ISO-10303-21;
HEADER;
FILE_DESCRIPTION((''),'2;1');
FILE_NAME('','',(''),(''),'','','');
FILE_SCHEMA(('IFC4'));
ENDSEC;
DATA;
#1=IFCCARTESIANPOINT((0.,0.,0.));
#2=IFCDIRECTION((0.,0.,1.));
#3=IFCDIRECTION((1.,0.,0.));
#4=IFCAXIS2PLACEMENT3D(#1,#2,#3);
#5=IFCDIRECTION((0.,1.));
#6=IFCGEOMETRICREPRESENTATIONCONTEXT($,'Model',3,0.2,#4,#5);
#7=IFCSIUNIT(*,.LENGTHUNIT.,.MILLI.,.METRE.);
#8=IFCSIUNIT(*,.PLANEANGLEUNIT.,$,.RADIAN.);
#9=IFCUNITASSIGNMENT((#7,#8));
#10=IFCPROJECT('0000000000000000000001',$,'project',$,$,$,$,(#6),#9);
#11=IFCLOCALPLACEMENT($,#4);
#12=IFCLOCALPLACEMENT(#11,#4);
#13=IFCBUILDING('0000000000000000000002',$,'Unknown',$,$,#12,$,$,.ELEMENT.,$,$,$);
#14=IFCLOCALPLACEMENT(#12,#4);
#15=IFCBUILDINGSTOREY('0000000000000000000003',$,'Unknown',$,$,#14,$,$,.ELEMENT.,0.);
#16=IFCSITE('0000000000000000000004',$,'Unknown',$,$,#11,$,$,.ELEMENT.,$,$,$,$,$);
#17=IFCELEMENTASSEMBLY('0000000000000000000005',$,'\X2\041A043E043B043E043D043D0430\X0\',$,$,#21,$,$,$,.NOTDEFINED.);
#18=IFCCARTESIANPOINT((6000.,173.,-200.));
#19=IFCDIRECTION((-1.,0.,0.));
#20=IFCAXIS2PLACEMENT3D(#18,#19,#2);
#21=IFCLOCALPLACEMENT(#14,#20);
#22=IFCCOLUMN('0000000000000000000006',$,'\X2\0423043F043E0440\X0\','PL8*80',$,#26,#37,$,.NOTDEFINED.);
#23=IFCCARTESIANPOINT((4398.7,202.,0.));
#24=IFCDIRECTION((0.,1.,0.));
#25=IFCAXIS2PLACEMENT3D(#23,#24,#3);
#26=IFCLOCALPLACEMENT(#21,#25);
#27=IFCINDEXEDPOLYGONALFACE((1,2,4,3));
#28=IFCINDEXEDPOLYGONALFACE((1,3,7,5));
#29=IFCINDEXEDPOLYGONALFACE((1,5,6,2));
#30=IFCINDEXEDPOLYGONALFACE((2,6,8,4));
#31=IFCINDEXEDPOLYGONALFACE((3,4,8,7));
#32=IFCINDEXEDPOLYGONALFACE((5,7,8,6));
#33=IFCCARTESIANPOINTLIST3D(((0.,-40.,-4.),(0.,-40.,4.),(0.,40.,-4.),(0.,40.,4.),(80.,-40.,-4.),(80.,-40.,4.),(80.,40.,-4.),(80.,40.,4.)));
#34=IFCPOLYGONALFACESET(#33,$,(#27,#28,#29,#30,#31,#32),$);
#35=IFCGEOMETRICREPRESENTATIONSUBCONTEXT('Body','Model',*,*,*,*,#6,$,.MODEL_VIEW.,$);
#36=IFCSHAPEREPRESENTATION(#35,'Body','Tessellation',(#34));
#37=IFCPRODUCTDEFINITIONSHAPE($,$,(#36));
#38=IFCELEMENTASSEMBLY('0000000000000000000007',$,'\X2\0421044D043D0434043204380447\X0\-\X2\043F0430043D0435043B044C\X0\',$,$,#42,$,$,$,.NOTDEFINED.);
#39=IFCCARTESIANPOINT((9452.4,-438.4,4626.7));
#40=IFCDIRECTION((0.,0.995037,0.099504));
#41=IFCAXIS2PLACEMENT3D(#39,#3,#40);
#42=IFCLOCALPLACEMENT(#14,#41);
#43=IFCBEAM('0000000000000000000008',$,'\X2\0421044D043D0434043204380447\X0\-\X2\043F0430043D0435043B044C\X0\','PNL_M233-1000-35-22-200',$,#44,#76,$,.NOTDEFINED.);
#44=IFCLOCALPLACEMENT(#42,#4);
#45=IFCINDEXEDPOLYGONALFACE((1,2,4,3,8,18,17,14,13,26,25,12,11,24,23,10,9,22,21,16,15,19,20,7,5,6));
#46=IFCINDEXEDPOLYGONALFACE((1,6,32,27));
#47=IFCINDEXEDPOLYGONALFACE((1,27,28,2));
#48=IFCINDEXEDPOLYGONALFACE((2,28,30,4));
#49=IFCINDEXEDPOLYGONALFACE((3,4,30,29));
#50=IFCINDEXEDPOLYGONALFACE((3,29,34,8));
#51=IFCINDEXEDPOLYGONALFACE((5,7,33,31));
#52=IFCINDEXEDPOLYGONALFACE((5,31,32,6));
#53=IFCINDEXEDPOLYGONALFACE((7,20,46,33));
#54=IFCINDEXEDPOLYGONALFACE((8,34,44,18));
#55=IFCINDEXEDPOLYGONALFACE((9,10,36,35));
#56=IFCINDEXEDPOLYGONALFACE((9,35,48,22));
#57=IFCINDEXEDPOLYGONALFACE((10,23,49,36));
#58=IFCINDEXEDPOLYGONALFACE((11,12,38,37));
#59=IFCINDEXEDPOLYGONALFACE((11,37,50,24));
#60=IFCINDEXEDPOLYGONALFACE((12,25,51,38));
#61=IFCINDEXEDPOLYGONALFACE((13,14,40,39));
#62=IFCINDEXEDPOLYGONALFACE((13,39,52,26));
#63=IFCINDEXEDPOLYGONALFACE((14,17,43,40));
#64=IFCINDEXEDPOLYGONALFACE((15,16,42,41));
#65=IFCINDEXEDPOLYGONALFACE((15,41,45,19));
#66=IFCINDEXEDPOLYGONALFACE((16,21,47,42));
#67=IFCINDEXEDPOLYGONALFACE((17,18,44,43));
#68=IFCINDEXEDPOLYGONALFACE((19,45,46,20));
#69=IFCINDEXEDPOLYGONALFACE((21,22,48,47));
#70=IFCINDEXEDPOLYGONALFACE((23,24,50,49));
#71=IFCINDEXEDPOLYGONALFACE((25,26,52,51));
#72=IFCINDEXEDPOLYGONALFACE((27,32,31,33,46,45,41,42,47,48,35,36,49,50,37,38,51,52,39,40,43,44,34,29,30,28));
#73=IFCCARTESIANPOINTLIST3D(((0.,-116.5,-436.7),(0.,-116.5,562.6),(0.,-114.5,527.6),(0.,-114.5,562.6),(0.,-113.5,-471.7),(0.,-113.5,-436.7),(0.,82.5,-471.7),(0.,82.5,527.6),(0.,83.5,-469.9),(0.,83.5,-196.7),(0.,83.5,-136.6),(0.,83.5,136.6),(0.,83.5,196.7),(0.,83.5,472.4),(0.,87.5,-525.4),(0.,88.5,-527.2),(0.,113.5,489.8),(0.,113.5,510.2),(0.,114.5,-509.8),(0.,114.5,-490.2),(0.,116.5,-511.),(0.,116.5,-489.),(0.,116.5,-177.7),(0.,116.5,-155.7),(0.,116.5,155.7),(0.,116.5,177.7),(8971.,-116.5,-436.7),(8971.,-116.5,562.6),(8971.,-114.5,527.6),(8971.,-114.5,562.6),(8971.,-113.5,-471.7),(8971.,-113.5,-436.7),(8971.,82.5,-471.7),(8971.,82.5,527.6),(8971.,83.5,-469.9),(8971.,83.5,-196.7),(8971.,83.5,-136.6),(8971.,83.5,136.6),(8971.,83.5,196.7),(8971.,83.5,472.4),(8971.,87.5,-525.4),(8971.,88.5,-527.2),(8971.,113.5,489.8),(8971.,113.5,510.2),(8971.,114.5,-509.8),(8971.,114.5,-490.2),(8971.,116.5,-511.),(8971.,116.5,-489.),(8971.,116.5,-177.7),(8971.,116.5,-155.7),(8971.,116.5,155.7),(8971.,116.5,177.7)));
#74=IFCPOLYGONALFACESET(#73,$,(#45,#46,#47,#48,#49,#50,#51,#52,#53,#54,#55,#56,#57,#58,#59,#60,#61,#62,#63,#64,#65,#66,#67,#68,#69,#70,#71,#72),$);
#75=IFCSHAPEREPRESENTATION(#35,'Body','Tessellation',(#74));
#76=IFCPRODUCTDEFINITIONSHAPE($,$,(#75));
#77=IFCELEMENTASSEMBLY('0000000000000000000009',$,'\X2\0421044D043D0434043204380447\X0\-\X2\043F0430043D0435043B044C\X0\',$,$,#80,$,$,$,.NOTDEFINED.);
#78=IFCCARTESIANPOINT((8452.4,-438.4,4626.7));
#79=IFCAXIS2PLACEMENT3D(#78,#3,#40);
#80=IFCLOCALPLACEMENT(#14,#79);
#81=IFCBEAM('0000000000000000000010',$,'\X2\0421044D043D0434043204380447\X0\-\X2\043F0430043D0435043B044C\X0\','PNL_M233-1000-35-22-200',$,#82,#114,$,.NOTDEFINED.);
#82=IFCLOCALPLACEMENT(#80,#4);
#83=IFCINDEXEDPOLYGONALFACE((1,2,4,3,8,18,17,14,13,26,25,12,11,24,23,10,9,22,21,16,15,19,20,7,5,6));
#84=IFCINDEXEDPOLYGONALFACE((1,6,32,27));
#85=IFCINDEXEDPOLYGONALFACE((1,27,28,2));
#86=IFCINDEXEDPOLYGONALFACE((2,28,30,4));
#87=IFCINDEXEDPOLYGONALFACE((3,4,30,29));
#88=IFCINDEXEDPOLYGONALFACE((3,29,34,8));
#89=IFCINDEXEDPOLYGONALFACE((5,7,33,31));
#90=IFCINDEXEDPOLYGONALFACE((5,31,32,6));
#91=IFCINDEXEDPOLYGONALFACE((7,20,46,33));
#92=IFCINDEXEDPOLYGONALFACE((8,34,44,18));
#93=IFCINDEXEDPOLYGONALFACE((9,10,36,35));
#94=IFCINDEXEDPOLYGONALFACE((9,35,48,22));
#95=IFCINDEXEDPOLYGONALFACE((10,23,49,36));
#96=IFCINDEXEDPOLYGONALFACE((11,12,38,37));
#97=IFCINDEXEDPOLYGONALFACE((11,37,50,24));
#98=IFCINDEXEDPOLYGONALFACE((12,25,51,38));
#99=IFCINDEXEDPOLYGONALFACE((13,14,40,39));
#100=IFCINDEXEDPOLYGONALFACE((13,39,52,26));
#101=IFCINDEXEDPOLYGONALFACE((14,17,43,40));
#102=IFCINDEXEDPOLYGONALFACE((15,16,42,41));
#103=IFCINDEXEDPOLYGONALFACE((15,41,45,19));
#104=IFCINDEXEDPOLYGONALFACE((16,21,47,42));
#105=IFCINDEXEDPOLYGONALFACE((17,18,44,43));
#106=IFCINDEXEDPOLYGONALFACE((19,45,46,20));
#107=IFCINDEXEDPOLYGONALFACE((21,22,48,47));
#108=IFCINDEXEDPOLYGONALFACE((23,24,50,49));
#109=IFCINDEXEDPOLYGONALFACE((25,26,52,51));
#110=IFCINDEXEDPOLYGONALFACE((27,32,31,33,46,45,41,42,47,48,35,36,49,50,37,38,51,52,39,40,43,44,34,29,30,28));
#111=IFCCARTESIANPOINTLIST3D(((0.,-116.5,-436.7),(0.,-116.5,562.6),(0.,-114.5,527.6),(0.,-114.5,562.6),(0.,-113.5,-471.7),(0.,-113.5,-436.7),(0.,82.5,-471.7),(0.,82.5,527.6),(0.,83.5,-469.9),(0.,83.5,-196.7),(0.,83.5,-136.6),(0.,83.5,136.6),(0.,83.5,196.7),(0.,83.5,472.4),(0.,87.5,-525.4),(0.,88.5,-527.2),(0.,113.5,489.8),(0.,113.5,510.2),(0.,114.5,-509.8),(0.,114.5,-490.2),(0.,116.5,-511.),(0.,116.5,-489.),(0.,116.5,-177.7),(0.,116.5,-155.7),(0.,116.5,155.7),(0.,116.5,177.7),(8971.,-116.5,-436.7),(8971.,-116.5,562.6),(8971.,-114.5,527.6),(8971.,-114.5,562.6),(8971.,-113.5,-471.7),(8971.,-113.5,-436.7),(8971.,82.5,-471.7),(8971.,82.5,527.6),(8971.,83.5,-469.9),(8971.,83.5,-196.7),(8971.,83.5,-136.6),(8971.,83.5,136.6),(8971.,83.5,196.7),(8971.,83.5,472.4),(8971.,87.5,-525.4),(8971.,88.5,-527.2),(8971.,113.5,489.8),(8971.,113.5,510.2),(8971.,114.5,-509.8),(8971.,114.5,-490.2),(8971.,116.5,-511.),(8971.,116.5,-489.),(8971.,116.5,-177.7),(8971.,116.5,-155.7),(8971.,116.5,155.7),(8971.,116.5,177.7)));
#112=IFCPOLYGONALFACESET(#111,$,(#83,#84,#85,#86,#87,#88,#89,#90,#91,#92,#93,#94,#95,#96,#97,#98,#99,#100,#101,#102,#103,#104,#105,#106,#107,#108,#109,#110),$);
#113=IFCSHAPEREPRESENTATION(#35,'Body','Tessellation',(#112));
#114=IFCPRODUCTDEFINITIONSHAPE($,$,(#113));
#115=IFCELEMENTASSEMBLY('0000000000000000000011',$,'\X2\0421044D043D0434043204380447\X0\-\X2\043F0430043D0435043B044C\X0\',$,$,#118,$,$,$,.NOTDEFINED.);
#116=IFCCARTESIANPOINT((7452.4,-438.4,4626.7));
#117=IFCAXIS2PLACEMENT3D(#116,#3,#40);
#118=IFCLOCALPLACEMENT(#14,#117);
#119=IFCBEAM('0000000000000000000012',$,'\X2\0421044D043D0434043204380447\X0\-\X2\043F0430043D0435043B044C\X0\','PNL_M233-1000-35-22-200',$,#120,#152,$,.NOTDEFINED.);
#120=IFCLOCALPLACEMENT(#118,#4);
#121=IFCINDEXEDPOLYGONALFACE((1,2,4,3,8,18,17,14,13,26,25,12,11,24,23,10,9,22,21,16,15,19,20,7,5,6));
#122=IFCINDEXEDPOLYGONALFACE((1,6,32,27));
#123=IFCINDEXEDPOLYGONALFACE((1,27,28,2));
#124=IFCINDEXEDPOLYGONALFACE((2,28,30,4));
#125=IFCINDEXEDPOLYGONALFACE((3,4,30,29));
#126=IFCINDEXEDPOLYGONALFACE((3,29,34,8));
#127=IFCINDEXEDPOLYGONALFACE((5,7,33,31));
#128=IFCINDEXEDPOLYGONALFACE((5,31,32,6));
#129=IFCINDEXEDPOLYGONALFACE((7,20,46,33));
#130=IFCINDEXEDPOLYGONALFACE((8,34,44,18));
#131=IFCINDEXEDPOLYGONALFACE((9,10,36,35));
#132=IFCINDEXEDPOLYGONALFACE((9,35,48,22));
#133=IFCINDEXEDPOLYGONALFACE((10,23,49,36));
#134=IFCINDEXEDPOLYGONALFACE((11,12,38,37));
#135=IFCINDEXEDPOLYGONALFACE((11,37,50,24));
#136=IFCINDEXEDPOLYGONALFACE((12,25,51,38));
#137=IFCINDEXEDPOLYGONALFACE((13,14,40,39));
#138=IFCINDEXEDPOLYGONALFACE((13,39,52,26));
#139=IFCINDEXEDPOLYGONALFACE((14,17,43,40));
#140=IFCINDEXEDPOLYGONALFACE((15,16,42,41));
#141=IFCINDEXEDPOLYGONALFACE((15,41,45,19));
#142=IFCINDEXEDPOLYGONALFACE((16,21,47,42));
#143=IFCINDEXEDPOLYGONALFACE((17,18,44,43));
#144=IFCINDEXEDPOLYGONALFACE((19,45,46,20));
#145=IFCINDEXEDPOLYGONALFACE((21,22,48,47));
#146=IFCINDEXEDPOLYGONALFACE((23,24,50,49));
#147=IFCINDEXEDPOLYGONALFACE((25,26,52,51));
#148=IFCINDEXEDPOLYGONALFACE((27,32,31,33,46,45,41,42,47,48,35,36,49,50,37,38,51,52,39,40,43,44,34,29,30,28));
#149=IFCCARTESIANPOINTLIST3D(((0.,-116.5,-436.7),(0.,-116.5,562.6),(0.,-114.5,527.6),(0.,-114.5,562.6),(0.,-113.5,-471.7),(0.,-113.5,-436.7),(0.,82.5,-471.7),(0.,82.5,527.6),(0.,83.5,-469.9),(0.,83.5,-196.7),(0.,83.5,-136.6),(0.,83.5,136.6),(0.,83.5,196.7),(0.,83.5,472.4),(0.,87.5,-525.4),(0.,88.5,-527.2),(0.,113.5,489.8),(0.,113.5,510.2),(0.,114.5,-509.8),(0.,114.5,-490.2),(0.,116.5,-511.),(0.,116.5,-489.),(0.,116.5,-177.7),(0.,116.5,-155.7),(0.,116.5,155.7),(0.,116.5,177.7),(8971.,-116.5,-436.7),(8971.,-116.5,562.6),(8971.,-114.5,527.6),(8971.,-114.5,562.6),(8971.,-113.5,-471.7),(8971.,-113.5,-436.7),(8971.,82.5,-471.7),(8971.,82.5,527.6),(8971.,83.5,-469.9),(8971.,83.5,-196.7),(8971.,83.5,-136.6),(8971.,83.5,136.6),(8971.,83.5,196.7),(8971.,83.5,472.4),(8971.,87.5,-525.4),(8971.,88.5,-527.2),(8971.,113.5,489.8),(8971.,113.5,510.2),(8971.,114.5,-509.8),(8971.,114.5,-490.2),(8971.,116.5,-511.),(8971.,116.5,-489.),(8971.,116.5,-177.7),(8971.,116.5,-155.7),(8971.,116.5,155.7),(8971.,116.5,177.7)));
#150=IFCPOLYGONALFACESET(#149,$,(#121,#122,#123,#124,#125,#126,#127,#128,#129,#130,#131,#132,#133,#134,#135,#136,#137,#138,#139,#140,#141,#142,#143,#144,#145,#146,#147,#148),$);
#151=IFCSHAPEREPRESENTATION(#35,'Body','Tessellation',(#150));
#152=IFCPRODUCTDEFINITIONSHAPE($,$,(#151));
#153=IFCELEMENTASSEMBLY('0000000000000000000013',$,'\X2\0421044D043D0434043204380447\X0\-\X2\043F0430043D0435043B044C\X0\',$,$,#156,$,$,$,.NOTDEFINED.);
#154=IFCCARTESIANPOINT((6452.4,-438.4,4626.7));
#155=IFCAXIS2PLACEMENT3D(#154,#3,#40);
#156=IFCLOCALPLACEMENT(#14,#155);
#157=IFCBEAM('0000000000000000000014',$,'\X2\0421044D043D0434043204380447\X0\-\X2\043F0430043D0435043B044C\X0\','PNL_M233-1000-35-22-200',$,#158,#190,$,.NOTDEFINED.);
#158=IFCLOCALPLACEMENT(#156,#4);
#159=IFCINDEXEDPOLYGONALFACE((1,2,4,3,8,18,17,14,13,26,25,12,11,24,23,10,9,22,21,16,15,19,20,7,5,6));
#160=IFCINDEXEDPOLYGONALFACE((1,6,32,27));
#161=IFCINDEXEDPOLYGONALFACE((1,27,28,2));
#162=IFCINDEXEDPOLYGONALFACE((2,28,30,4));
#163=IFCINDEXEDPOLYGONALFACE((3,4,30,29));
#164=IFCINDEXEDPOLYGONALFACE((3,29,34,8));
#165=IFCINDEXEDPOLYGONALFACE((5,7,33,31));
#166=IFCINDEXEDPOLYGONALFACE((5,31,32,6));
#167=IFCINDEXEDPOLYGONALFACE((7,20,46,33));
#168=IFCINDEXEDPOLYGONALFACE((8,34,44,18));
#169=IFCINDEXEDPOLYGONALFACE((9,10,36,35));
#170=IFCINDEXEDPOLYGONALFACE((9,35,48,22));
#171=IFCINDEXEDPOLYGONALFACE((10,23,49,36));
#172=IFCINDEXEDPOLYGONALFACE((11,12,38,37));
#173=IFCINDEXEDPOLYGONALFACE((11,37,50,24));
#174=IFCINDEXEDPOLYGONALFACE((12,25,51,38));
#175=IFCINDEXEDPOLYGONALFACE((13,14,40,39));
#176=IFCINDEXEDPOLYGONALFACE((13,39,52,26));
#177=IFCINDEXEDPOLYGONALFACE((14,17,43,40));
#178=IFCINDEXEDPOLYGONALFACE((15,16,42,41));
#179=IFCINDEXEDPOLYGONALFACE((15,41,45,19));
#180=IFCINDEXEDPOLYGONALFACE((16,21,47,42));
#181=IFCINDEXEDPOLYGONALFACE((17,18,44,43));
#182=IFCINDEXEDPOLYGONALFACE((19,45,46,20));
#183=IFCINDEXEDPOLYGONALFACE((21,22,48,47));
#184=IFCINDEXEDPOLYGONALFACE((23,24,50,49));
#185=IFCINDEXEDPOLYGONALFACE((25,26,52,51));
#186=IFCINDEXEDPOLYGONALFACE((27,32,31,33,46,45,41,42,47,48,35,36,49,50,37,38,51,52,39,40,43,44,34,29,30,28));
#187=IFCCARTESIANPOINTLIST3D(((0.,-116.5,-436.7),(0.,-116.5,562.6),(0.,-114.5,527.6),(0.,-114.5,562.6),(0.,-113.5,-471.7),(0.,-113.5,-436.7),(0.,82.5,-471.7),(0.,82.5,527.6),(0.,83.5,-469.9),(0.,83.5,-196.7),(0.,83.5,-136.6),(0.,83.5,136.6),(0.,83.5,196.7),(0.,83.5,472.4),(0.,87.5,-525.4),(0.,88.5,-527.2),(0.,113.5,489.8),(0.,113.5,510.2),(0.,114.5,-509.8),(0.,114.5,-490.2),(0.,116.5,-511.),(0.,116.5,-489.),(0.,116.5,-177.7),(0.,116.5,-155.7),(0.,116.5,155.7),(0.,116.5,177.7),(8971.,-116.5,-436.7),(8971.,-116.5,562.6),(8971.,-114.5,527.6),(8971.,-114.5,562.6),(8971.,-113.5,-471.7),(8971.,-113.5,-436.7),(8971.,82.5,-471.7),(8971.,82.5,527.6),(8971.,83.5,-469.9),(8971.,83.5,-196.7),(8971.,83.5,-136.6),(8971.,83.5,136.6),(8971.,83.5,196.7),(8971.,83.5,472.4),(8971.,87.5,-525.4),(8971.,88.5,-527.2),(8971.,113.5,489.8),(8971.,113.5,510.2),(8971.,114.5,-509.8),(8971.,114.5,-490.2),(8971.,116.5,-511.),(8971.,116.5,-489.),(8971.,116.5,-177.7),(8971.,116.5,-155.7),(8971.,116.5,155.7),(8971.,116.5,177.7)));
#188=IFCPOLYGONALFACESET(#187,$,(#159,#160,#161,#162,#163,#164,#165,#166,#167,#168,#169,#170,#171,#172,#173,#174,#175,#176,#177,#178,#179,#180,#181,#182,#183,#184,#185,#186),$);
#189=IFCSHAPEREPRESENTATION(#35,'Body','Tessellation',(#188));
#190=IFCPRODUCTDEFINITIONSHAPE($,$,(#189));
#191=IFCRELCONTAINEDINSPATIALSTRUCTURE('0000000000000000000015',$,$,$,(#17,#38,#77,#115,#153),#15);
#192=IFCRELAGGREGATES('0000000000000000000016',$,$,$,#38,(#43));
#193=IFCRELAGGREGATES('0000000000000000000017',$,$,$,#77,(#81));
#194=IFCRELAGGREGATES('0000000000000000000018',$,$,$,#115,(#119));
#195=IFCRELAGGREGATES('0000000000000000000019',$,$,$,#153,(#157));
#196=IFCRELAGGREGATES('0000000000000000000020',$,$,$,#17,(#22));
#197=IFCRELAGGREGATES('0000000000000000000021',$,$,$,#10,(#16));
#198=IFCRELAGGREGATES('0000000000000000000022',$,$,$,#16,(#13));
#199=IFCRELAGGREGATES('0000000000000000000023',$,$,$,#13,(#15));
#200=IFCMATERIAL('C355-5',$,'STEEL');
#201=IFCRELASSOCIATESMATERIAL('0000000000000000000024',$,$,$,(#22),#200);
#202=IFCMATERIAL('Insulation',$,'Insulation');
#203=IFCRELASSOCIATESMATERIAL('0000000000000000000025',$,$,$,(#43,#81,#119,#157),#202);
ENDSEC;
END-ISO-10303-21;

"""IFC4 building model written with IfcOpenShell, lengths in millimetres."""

from ifc_helpers import new_model, si_unit, direction, frame, origin_with_axes, place, context, subcontext, project, spatial, line, indexed_curve, outline, extrude, material, element, aggregate, save


model = new_model("IFC4")

# Units and contexts
model_context = context("Model", 3, precision=0.2, world=origin_with_axes(), true_north=direction((0.0, 1.0)))
body_context = subcontext(model_context, "Body", "Model", "MODEL_VIEW")
ifc_project = project(units=[si_unit("LENGTHUNIT", "METRE", prefix="MILLI"), si_unit("PLANEANGLEUNIT", "RADIAN")], contexts=[model_context])

# Site, building, storey
site_placement = place(None, origin_with_axes())
site = spatial("IfcSite", under=ifc_project, at=site_placement, Name="Unknown", CompositionType="ELEMENT")
building_placement = place(site_placement, origin_with_axes())
building = spatial("IfcBuilding", under=site, at=building_placement, Name="Unknown", CompositionType="ELEMENT")
storey_placement = place(building_placement, origin_with_axes())
storey = spatial("IfcBuildingStorey", under=building, at=storey_placement, Name="Unknown", CompositionType="ELEMENT", Elevation=0.0)

# Element assembly, column
assembly_1_placement = place(storey_placement, frame((6000.0, 173.0, -200.0), z_axis=(-1.0, 0.0, 0.0), x_axis=(0.0, 0.0, 1.0)))
assembly_1 = element("IfcElementAssembly", 1, at=assembly_1_placement, inside=storey, Name="Колонна", PredefinedType="NOTDEFINED")
ifc_material_1 = material(Name="C355-5", Category="STEEL")
column_1_placement = place(assembly_1_placement, frame((4398.7, 202.0, 0.0), z_axis=(0.0, 1.0, 0.0), x_axis=(1.0, 0.0, 0.0)))
column_1 = element("IfcColumn", 2, at=column_1_placement, material=ifc_material_1, Name="Упор", Description="PL8*80", PredefinedType="NOTDEFINED", context=body_context, shape_type="SolidModel", body=[
    extrude(outline(indexed_curve([(-4.0, -40.0), (4.0, -40.0), (4.0, 40.0), (-4.0, 40.0)], segments=[line(1, 2, 3, 4, 1)])), frame((0.0, 0.0, 0.0), z_axis=(-1.0, 0.0, 0.0), x_axis=(0.0, 0.0, 1.0)), (0.0, 0.0, -1.0), 80.0),
])

# Element assemblies, beams
assembly_2_placement = place(storey_placement, frame((9452.4, -438.4, 4626.7), z_axis=(1.0, 0.0, 0.0), x_axis=(0.0, 0.995037, 0.099504)))
assembly_2 = element("IfcElementAssembly", 3, at=assembly_2_placement, inside=storey, Name="Сэндвич-панель", PredefinedType="NOTDEFINED")
ifc_material_2 = material(Name="Insulation", Category="Insulation")
beam_1_placement = place(assembly_2_placement, origin_with_axes())
beam_1 = element("IfcBeam", 4, at=beam_1_placement, material=ifc_material_2, Name="Сэндвич-панель", Description="PNL_M233-1000-35-22-200", PredefinedType="NOTDEFINED", context=body_context, shape_type="SolidModel", body=[
    extrude(outline(indexed_curve([(-509.8, 114.5), (-490.2, 114.5), (-471.7, 82.5), (-471.7, -113.5), (-436.7, -113.5), (-436.7, -116.5), (562.6, -116.5), (562.6, -114.5), (527.6, -114.5), (527.6, 82.5), (510.2, 113.5), (489.8, 113.5), (472.4, 83.5), (196.7, 83.5), (177.7, 116.5), (155.7, 116.5), (136.6, 83.5), (-136.6, 83.5), (-155.7, 116.5), (-177.7, 116.5), (-196.7, 83.5), (-469.9, 83.5), (-489.0, 116.5), (-511.0, 116.5), (-527.2, 88.5), (-525.4, 87.5)], segments=[line(1, 2, 3, 4, 5, 6, 7, 8, 9, 10, 11, 12, 13, 14, 15, 16, 17, 18, 19, 20, 21, 22, 23, 24, 25, 26, 1)])), frame((0.0, 0.0, 0.0), z_axis=(-1.0, 0.0, 0.0), x_axis=(0.0, 0.0, 1.0)), (0.0, 0.0, -1.0), 8971.0),
])
aggregate(assembly_2, [beam_1])
assembly_3_placement = place(storey_placement, frame((8452.4, -438.4, 4626.7), z_axis=(1.0, 0.0, 0.0), x_axis=(0.0, 0.995037, 0.099504)))
assembly_3 = element("IfcElementAssembly", 5, at=assembly_3_placement, inside=storey, Name="Сэндвич-панель", PredefinedType="NOTDEFINED")
beam_2_placement = place(assembly_3_placement, origin_with_axes())
beam_2 = element("IfcBeam", 6, at=beam_2_placement, material=ifc_material_2, Name="Сэндвич-панель", Description="PNL_M233-1000-35-22-200", PredefinedType="NOTDEFINED", context=body_context, shape_type="SolidModel", body=[
    extrude(outline(indexed_curve([(-509.8, 114.5), (-490.2, 114.5), (-471.7, 82.5), (-471.7, -113.5), (-436.7, -113.5), (-436.7, -116.5), (562.6, -116.5), (562.6, -114.5), (527.6, -114.5), (527.6, 82.5), (510.2, 113.5), (489.8, 113.5), (472.4, 83.5), (196.7, 83.5), (177.7, 116.5), (155.7, 116.5), (136.6, 83.5), (-136.6, 83.5), (-155.7, 116.5), (-177.7, 116.5), (-196.7, 83.5), (-469.9, 83.5), (-489.0, 116.5), (-511.0, 116.5), (-527.2, 88.5), (-525.4, 87.5)], segments=[line(1, 2, 3, 4, 5, 6, 7, 8, 9, 10, 11, 12, 13, 14, 15, 16, 17, 18, 19, 20, 21, 22, 23, 24, 25, 26, 1)])), frame((0.0, 0.0, 0.0), z_axis=(-1.0, 0.0, 0.0), x_axis=(0.0, 0.0, 1.0)), (0.0, 0.0, -1.0), 8971.0),
])
aggregate(assembly_3, [beam_2])
assembly_4_placement = place(storey_placement, frame((7452.4, -438.4, 4626.7), z_axis=(1.0, 0.0, 0.0), x_axis=(0.0, 0.995037, 0.099504)))
assembly_4 = element("IfcElementAssembly", 7, at=assembly_4_placement, inside=storey, Name="Сэндвич-панель", PredefinedType="NOTDEFINED")
beam_3_placement = place(assembly_4_placement, origin_with_axes())
beam_3 = element("IfcBeam", 8, at=beam_3_placement, material=ifc_material_2, Name="Сэндвич-панель", Description="PNL_M233-1000-35-22-200", PredefinedType="NOTDEFINED", context=body_context, shape_type="SolidModel", body=[
    extrude(outline(indexed_curve([(-509.8, 114.5), (-490.2, 114.5), (-471.7, 82.5), (-471.7, -113.5), (-436.7, -113.5), (-436.7, -116.5), (562.6, -116.5), (562.6, -114.5), (527.6, -114.5), (527.6, 82.5), (510.2, 113.5), (489.8, 113.5), (472.4, 83.5), (196.7, 83.5), (177.7, 116.5), (155.7, 116.5), (136.6, 83.5), (-136.6, 83.5), (-155.7, 116.5), (-177.7, 116.5), (-196.7, 83.5), (-469.9, 83.5), (-489.0, 116.5), (-511.0, 116.5), (-527.2, 88.5), (-525.4, 87.5)], segments=[line(1, 2, 3, 4, 5, 6, 7, 8, 9, 10, 11, 12, 13, 14, 15, 16, 17, 18, 19, 20, 21, 22, 23, 24, 25, 26, 1)])), frame((0.0, 0.0, 0.0), z_axis=(-1.0, 0.0, 0.0), x_axis=(0.0, 0.0, 1.0)), (0.0, 0.0, -1.0), 8971.0),
])
aggregate(assembly_4, [beam_3])
assembly_5_placement = place(storey_placement, frame((6452.4, -438.4, 4626.7), z_axis=(1.0, 0.0, 0.0), x_axis=(0.0, 0.995037, 0.099504)))
assembly_5 = element("IfcElementAssembly", 9, at=assembly_5_placement, inside=storey, Name="Сэндвич-панель", PredefinedType="NOTDEFINED")
beam_4_placement = place(assembly_5_placement, origin_with_axes())
beam_4 = element("IfcBeam", 10, at=beam_4_placement, material=ifc_material_2, Name="Сэндвич-панель", Description="PNL_M233-1000-35-22-200", PredefinedType="NOTDEFINED", context=body_context, shape_type="SolidModel", body=[
    extrude(outline(indexed_curve([(-509.8, 114.5), (-490.2, 114.5), (-471.7, 82.5), (-471.7, -113.5), (-436.7, -113.5), (-436.7, -116.5), (562.6, -116.5), (562.6, -114.5), (527.6, -114.5), (527.6, 82.5), (510.2, 113.5), (489.8, 113.5), (472.4, 83.5), (196.7, 83.5), (177.7, 116.5), (155.7, 116.5), (136.6, 83.5), (-136.6, 83.5), (-155.7, 116.5), (-177.7, 116.5), (-196.7, 83.5), (-469.9, 83.5), (-489.0, 116.5), (-511.0, 116.5), (-527.2, 88.5), (-525.4, 87.5)], segments=[line(1, 2, 3, 4, 5, 6, 7, 8, 9, 10, 11, 12, 13, 14, 15, 16, 17, 18, 19, 20, 21, 22, 23, 24, 25, 26, 1)])), frame((0.0, 0.0, 0.0), z_axis=(-1.0, 0.0, 0.0), x_axis=(0.0, 0.0, 1.0)), (0.0, 0.0, -1.0), 8971.0),
])
aggregate(assembly_5, [beam_4])

aggregate(assembly_1, [column_1])

save(model, "model.ifc")
